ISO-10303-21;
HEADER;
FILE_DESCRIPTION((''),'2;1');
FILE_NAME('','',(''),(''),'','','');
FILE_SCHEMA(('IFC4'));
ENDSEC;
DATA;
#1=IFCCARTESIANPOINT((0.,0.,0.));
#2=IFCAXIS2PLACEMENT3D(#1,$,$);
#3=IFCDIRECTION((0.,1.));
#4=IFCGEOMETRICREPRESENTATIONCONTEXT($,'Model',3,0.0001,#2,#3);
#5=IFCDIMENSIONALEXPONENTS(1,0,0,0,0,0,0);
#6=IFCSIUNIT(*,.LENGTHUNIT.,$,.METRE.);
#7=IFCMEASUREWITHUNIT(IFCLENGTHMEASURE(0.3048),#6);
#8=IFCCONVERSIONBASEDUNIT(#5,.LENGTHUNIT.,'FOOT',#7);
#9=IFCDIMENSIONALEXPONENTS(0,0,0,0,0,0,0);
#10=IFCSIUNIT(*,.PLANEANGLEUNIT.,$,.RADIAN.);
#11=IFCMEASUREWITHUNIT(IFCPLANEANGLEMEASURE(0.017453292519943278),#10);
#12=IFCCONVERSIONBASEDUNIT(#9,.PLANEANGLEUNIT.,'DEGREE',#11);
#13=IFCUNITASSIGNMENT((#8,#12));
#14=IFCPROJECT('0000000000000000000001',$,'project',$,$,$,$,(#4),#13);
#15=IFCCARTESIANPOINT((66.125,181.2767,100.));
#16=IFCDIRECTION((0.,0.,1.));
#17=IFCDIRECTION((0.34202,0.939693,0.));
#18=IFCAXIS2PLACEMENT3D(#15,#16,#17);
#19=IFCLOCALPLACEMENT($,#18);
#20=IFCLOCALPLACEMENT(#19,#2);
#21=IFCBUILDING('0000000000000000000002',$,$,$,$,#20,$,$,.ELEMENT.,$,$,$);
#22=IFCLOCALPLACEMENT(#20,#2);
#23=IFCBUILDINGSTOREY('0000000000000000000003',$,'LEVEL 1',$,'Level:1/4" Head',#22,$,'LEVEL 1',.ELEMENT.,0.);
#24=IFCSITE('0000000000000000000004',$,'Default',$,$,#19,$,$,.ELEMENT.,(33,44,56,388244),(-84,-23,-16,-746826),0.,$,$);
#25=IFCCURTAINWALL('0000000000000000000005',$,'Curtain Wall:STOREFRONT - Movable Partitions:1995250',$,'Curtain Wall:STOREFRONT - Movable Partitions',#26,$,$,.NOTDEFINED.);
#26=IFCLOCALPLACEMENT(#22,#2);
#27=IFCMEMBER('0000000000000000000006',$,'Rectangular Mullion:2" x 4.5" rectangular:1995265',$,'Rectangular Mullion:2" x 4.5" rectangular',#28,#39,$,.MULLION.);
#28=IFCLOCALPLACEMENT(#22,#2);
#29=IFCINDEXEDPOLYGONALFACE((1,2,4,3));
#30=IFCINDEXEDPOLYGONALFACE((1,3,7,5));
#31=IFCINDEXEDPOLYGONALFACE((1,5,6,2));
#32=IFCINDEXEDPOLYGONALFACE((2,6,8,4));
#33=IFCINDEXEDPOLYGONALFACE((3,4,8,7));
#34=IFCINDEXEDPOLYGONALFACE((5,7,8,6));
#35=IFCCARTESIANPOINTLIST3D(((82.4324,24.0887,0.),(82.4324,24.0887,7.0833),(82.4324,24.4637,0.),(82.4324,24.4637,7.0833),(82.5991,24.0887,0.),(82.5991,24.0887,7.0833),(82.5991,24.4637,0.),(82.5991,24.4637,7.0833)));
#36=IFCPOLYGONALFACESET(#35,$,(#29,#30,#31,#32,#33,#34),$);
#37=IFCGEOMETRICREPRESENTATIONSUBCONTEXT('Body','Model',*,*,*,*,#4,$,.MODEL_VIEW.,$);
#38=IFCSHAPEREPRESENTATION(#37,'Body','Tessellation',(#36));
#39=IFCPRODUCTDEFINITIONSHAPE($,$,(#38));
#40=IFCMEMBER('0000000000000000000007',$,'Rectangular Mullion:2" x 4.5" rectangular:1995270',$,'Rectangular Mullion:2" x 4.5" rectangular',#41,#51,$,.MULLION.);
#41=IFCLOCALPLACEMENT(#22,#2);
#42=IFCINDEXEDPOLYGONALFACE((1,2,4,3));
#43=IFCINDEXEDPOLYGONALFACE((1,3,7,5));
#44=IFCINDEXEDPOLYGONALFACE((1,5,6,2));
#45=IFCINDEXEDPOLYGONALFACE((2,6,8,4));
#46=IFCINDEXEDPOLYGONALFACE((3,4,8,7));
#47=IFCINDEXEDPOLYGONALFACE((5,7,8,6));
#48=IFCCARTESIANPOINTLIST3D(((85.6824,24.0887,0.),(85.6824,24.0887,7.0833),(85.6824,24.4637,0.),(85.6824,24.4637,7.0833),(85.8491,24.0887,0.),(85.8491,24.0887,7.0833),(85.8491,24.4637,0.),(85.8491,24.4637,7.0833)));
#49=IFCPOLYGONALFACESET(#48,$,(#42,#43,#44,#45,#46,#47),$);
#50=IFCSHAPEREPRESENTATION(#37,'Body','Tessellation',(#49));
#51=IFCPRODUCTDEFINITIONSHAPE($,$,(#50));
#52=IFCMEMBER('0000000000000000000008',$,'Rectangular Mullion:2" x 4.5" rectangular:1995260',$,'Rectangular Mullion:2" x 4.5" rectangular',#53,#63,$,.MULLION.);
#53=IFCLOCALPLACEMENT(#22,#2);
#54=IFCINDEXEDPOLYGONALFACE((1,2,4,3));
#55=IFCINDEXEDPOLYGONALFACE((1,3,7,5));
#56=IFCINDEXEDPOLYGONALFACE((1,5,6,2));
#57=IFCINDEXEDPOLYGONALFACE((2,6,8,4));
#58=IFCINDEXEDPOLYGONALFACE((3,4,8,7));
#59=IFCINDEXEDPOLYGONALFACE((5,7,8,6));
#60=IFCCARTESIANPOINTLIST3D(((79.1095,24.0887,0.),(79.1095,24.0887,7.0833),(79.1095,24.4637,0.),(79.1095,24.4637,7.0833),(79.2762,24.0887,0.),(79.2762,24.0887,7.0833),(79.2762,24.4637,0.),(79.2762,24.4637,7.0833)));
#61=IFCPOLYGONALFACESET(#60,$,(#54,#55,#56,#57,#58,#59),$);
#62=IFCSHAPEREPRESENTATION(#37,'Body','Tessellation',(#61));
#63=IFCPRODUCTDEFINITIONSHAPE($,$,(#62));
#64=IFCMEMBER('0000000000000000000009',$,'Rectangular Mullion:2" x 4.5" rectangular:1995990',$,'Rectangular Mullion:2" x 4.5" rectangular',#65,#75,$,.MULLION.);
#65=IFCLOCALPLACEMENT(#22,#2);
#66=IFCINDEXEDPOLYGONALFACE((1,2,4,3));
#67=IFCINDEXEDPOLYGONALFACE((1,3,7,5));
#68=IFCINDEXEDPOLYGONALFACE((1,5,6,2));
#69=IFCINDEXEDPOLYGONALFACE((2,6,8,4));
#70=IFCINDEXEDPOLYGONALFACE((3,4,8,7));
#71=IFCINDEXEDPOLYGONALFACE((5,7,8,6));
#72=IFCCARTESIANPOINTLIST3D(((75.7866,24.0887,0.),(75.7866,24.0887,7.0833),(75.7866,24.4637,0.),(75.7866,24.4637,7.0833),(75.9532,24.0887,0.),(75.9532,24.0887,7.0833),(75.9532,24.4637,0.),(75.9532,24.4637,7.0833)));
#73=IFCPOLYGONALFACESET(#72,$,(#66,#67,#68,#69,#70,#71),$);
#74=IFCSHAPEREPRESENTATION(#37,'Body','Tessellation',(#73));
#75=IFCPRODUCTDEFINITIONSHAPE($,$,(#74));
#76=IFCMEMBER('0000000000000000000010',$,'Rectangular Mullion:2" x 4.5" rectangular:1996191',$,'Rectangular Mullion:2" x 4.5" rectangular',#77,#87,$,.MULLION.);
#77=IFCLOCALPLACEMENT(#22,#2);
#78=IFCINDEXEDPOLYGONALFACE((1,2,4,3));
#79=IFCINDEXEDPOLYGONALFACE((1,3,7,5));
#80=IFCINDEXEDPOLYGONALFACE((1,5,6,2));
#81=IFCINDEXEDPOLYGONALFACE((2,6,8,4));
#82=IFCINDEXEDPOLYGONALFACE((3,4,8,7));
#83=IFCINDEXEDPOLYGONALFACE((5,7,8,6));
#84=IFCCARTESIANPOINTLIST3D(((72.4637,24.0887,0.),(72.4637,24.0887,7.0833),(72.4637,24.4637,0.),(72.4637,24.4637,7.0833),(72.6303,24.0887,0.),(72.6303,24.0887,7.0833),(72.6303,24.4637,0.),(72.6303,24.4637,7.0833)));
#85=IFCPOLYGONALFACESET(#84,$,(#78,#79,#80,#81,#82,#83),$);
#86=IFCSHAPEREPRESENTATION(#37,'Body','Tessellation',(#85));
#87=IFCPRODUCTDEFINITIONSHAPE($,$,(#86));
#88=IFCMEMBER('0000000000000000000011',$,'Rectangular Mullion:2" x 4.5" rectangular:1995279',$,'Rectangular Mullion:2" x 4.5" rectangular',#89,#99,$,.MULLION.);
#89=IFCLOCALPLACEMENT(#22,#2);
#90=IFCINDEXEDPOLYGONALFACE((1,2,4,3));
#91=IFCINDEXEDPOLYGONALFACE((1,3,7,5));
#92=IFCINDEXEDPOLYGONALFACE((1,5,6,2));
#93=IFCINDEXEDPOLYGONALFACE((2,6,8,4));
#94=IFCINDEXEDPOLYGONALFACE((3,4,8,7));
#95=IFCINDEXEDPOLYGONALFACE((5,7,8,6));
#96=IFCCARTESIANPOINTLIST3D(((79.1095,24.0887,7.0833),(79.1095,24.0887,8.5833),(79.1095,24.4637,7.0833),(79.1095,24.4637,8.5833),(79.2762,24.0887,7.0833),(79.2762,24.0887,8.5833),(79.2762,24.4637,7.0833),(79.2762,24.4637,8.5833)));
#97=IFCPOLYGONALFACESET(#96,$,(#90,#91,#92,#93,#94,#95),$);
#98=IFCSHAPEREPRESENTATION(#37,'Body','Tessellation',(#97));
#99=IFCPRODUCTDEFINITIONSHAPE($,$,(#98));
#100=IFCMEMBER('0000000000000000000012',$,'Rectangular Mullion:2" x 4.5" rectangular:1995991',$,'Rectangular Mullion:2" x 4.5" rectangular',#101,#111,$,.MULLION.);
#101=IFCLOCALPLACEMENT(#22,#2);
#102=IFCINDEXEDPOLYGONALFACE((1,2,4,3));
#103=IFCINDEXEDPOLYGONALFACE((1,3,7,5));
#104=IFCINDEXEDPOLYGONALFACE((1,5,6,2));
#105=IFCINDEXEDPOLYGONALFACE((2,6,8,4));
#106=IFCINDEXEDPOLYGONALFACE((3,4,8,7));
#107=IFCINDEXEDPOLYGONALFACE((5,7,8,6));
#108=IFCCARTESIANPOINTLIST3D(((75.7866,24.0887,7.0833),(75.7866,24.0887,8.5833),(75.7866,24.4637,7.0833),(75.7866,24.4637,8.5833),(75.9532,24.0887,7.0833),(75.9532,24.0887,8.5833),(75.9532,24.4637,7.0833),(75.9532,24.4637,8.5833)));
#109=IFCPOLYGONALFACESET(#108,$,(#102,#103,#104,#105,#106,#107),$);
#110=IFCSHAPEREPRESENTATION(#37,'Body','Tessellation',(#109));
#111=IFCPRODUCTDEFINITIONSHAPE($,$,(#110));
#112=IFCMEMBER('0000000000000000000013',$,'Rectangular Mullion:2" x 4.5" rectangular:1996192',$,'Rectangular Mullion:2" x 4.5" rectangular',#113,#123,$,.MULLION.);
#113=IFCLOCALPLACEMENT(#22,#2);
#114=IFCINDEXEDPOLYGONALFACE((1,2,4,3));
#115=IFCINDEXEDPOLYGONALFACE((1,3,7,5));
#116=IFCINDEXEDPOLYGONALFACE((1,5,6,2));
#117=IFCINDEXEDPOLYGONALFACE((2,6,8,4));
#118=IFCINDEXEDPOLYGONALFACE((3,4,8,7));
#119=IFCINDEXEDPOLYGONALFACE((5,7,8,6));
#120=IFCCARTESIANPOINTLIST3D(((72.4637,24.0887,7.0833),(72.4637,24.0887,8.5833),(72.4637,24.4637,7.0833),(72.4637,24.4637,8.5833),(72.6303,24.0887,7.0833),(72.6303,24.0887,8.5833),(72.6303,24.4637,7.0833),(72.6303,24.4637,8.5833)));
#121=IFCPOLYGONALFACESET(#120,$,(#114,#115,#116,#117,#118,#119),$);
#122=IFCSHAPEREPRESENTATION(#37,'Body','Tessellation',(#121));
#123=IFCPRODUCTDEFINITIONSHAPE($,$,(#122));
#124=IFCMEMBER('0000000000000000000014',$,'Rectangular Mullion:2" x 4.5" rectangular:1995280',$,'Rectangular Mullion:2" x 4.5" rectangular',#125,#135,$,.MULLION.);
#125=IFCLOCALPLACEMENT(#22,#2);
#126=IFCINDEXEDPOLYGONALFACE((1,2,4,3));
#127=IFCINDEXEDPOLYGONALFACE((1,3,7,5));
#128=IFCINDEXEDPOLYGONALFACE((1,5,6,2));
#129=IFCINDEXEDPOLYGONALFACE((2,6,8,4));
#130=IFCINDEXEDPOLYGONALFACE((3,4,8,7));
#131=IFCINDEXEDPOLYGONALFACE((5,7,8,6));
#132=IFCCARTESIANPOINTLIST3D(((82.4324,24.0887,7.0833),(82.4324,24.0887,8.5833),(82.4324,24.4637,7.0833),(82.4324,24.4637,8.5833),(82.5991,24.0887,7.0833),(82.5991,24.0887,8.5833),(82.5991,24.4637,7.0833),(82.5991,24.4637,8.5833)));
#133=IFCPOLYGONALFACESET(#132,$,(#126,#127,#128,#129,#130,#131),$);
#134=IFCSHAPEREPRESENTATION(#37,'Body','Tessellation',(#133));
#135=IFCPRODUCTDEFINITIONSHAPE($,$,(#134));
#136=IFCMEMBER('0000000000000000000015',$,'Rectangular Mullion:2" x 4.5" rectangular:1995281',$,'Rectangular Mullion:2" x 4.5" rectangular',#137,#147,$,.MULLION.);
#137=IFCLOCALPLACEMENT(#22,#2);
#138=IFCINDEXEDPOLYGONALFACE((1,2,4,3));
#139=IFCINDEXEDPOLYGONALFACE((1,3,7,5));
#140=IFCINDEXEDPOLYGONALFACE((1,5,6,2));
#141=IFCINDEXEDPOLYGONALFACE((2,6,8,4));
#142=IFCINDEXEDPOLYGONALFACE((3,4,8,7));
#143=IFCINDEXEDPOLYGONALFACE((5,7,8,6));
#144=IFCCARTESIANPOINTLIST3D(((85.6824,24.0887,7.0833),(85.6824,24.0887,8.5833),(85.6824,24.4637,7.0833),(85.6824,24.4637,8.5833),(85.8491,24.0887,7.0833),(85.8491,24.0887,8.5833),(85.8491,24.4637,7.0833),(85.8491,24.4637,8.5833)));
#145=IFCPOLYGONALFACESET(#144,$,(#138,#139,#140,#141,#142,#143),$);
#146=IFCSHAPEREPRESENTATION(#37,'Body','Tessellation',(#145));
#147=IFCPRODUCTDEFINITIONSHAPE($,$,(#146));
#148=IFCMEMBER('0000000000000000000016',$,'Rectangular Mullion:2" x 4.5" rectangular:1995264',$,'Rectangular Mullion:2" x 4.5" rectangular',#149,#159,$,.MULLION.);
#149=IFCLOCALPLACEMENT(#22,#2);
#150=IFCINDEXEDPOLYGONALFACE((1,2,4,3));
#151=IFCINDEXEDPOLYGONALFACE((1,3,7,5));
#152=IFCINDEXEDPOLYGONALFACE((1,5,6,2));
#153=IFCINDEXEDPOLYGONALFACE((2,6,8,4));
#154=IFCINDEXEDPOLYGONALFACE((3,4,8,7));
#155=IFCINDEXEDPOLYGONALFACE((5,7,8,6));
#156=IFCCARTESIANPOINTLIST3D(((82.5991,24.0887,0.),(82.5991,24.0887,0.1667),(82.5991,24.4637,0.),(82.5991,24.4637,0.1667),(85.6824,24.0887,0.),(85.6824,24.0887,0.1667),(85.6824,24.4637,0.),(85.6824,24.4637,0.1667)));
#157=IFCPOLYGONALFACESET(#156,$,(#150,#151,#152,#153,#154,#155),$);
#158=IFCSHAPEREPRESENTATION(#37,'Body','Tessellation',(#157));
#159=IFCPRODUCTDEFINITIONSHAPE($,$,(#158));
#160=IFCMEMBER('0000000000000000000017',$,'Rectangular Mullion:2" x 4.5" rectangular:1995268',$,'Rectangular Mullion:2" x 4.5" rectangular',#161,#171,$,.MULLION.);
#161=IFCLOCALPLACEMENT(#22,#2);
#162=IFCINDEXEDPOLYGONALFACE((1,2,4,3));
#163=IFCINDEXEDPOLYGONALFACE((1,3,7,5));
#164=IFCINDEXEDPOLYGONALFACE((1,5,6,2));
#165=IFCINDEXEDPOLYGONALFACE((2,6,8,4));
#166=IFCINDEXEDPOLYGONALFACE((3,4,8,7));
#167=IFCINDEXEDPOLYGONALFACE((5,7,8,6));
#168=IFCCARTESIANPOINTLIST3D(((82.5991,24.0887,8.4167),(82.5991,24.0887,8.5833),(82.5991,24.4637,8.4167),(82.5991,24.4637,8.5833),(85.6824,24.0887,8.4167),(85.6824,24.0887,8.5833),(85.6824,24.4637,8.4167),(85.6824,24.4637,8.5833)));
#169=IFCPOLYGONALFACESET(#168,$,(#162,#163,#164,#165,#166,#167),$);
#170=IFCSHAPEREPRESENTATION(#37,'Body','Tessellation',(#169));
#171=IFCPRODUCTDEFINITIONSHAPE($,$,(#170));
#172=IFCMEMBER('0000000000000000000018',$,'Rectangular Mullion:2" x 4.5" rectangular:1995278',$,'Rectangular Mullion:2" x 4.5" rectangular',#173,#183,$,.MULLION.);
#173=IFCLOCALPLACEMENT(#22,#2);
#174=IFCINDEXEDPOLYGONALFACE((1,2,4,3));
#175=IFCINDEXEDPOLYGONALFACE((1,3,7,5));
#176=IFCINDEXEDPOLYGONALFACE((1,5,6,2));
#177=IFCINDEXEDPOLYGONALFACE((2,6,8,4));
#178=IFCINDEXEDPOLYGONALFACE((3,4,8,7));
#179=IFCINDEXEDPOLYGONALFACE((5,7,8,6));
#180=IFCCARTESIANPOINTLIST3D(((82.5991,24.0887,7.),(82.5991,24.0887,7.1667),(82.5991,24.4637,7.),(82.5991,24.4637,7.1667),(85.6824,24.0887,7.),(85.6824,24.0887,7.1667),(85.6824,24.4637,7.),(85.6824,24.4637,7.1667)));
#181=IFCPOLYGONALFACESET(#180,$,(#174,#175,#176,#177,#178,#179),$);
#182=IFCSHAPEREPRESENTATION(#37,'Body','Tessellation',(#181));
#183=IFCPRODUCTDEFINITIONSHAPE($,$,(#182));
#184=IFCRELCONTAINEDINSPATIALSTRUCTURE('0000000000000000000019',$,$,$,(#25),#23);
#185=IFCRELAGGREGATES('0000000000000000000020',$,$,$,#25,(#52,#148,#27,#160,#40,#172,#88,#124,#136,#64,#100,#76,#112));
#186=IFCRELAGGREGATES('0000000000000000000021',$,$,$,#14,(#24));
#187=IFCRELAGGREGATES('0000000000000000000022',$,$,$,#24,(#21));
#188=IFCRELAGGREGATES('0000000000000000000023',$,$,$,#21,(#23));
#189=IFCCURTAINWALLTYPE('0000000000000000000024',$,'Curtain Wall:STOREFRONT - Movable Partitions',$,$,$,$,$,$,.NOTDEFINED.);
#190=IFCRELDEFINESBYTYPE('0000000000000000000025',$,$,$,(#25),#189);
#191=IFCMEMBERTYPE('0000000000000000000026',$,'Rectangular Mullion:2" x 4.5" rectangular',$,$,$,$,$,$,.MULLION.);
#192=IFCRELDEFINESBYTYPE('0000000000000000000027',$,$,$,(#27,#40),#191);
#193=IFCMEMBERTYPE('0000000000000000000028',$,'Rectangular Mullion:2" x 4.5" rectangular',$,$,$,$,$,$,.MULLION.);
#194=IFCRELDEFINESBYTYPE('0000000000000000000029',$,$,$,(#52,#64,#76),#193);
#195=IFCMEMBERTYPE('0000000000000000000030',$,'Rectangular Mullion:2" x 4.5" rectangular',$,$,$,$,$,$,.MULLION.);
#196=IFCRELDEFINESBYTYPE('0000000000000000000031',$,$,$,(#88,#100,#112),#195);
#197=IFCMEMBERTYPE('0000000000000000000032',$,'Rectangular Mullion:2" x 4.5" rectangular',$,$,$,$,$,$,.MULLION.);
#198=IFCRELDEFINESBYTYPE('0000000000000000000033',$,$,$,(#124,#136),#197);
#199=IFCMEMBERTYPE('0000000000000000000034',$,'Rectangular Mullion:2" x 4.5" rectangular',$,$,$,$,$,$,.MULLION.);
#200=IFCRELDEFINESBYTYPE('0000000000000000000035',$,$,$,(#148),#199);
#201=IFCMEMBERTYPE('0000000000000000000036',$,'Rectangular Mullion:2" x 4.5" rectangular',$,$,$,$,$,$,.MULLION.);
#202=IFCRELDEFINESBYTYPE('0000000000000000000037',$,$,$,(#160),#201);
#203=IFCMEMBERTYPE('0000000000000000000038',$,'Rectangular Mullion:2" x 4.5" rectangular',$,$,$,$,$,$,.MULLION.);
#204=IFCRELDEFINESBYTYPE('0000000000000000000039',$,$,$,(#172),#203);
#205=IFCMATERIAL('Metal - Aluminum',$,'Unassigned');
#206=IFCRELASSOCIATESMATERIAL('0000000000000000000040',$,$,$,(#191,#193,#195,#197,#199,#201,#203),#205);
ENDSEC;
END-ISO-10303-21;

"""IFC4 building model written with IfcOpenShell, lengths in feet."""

from ifc_helpers import new_model, entity, si_unit, converted_unit, direction, frame, frame_2d, origin, origin_2d_with_axis, place, context, subcontext, project, spatial, rectangle, extrude, source, transform, mapped, material, material_profile, profile_set, type_object, type_shapes, element, aggregate, save


model = new_model("IFC4")

# Units and contexts
model_context = context("Model", 3, precision=0.0001, world=origin(), true_north=direction((0.0, 1.0)))
body_context = subcontext(model_context, "Body", "Model", "MODEL_VIEW")
ifc_project = project(units=[converted_unit("LENGTHUNIT", "FOOT", entity("IfcLengthMeasure", 0.3048), si_unit("LENGTHUNIT", "METRE"), dimensions=[1, 0, 0, 0, 0, 0, 0]), converted_unit("PLANEANGLEUNIT", "DEGREE", entity("IfcPlaneAngleMeasure", 0.017453292519943278), si_unit("PLANEANGLEUNIT", "RADIAN"), dimensions=[0, 0, 0, 0, 0, 0, 0])], contexts=[model_context])

# Site, building, storey
site_placement = place(None, frame((66.125, 181.2767, 100.0), z_axis=(0.0, 0.0, 1.0), x_axis=(0.34202, 0.939693, 0.0)))
site = spatial("IfcSite", under=ifc_project, at=site_placement, Name="Default", CompositionType="ELEMENT", RefLatitude=(33, 44, 56, 388244), RefLongitude=(-84, -23, -16, -746826), RefElevation=0.0)
building_placement = place(site_placement, origin())
building = spatial("IfcBuilding", under=site, at=building_placement, CompositionType="ELEMENT")
storey_placement = place(building_placement, origin())
storey = spatial("IfcBuildingStorey", under=building, at=storey_placement, Name="LEVEL 1", ObjectType="Level:1/4\" Head", LongName="LEVEL 1", CompositionType="ELEMENT", Elevation=0.0)

# Curtain wall, members
curtain_wall_type = type_object("IfcCurtainWallType", Name="Curtain Wall:STOREFRONT - Movable Partitions", PredefinedType="NOTDEFINED")
curtain_wall_1_placement = place(storey_placement, origin())
curtain_wall_1 = element("IfcCurtainWall", 1, at=curtain_wall_1_placement, inside=storey, type_object=curtain_wall_type, Name="Curtain Wall:STOREFRONT - Movable Partitions:1995250", ObjectType="Curtain Wall:STOREFRONT - Movable Partitions", PredefinedType="NOTDEFINED")
ifc_material_1 = material(Name="Metal - Aluminum", Category="Unassigned")
ifc_material_profile_1 = material_profile(ifc_material_1, rectangle(XDim=0.1667, YDim=0.375, at=origin_2d_with_axis()), Name="2\" x 4.5\" rectangular")
ifc_profile_set_1 = profile_set([ifc_material_profile_1], Name="2\" x 4.5\" rectangular")
member_type_1 = type_object("IfcMemberType", Name="Rectangular Mullion:2\" x 4.5\" rectangular", PredefinedType="MULLION", material=ifc_profile_set_1)
shared_shape_1 = source(origin(), body_context, "Body", "SweptSolid", [
    extrude(rectangle(XDim=0.1667, YDim=0.375, at=origin_2d_with_axis()), frame((0.0, 0.0, -7.0833), z_axis=(0.0, 0.0, 1.0), x_axis=(-1.0, 0.0, 0.0)), (0.0, 0.0, 1.0), 7.0833),
])
type_shapes(member_type_1, [shared_shape_1])
member_1_placement = place(curtain_wall_1_placement, frame((82.5157, 24.2762, 0.0), z_axis=(0.0, 0.0, -1.0), x_axis=(1.0, 0.0, 0.0)))
member_1 = element("IfcMember", 2, at=member_1_placement, type_object=member_type_1, Name="Rectangular Mullion:2\" x 4.5\" rectangular:1995265", ObjectType="Rectangular Mullion:2\" x 4.5\" rectangular", PredefinedType="MULLION", context=body_context, shape_type="MappedRepresentation", body=[
    mapped(shared_shape_1, transform((0.0, 0.0, 0.0), scale=1.0)),
])
member_2_placement = place(curtain_wall_1_placement, frame((85.7657, 24.2762, 0.0), z_axis=(0.0, 0.0, -1.0), x_axis=(1.0, 0.0, 0.0)))
member_2 = element("IfcMember", 3, at=member_2_placement, type_object=member_type_1, Name="Rectangular Mullion:2\" x 4.5\" rectangular:1995270", ObjectType="Rectangular Mullion:2\" x 4.5\" rectangular", PredefinedType="MULLION", context=body_context, shape_type="MappedRepresentation", body=[
    mapped(shared_shape_1, transform((0.0, 0.0, 0.0), scale=1.0)),
])
member_type_2 = type_object("IfcMemberType", Name="Rectangular Mullion:2\" x 4.5\" rectangular", PredefinedType="MULLION", material=ifc_profile_set_1)
shared_shape_2 = source(origin(), body_context, "Body", "SweptSolid", [
    extrude(rectangle(XDim=0.1667, YDim=0.375, at=origin_2d_with_axis()), frame((0.0, 0.0, -7.0833), z_axis=(0.0, 0.0, 1.0), x_axis=(-1.0, 0.0, 0.0)), (0.0, 0.0, 1.0), 7.0833),
])
type_shapes(member_type_2, [shared_shape_2])
member_3_placement = place(curtain_wall_1_placement, frame((79.1928, 24.2762, 0.0), z_axis=(0.0, 0.0, -1.0), x_axis=(1.0, 0.0, 0.0)))
member_3 = element("IfcMember", 4, at=member_3_placement, type_object=member_type_2, Name="Rectangular Mullion:2\" x 4.5\" rectangular:1995260", ObjectType="Rectangular Mullion:2\" x 4.5\" rectangular", PredefinedType="MULLION", context=body_context, shape_type="MappedRepresentation", body=[
    mapped(shared_shape_2, transform((0.0, 0.0, 0.0), scale=1.0)),
])
member_4_placement = place(curtain_wall_1_placement, frame((75.8699, 24.2762, 0.0), z_axis=(0.0, 0.0, -1.0), x_axis=(1.0, 0.0, 0.0)))
member_4 = element("IfcMember", 5, at=member_4_placement, type_object=member_type_2, Name="Rectangular Mullion:2\" x 4.5\" rectangular:1995990", ObjectType="Rectangular Mullion:2\" x 4.5\" rectangular", PredefinedType="MULLION", context=body_context, shape_type="MappedRepresentation", body=[
    mapped(shared_shape_2, transform((0.0, 0.0, 0.0), scale=1.0)),
])
member_5_placement = place(curtain_wall_1_placement, frame((72.547, 24.2762, 0.0), z_axis=(0.0, 0.0, -1.0), x_axis=(1.0, 0.0, 0.0)))
member_5 = element("IfcMember", 6, at=member_5_placement, type_object=member_type_2, Name="Rectangular Mullion:2\" x 4.5\" rectangular:1996191", ObjectType="Rectangular Mullion:2\" x 4.5\" rectangular", PredefinedType="MULLION", context=body_context, shape_type="MappedRepresentation", body=[
    mapped(shared_shape_2, transform((0.0, 0.0, 0.0), scale=1.0)),
])
member_type_3 = type_object("IfcMemberType", Name="Rectangular Mullion:2\" x 4.5\" rectangular", PredefinedType="MULLION", material=ifc_profile_set_1)
shared_shape_3 = source(origin(), body_context, "Body", "SweptSolid", [
    extrude(rectangle(XDim=0.1667, YDim=0.375, at=origin_2d_with_axis()), frame((0.0, 0.0, -1.5), z_axis=(0.0, 0.0, 1.0), x_axis=(-1.0, 0.0, 0.0)), (0.0, 0.0, 1.0), 1.5),
])
type_shapes(member_type_3, [shared_shape_3])
member_6_placement = place(curtain_wall_1_placement, frame((79.1928, 24.2762, 7.0833), z_axis=(0.0, 0.0, -1.0), x_axis=(1.0, 0.0, 0.0)))
member_6 = element("IfcMember", 7, at=member_6_placement, type_object=member_type_3, Name="Rectangular Mullion:2\" x 4.5\" rectangular:1995279", ObjectType="Rectangular Mullion:2\" x 4.5\" rectangular", PredefinedType="MULLION", context=body_context, shape_type="MappedRepresentation", body=[
    mapped(shared_shape_3, transform((0.0, 0.0, 0.0), scale=1.0)),
])
member_7_placement = place(curtain_wall_1_placement, frame((75.8699, 24.2762, 7.0833), z_axis=(0.0, 0.0, -1.0), x_axis=(1.0, 0.0, 0.0)))
member_7 = element("IfcMember", 8, at=member_7_placement, type_object=member_type_3, Name="Rectangular Mullion:2\" x 4.5\" rectangular:1995991", ObjectType="Rectangular Mullion:2\" x 4.5\" rectangular", PredefinedType="MULLION", context=body_context, shape_type="MappedRepresentation", body=[
    mapped(shared_shape_3, transform((0.0, 0.0, 0.0), scale=1.0)),
])
member_8_placement = place(curtain_wall_1_placement, frame((72.547, 24.2762, 7.0833), z_axis=(0.0, 0.0, -1.0), x_axis=(1.0, 0.0, 0.0)))
member_8 = element("IfcMember", 9, at=member_8_placement, type_object=member_type_3, Name="Rectangular Mullion:2\" x 4.5\" rectangular:1996192", ObjectType="Rectangular Mullion:2\" x 4.5\" rectangular", PredefinedType="MULLION", context=body_context, shape_type="MappedRepresentation", body=[
    mapped(shared_shape_3, transform((0.0, 0.0, 0.0), scale=1.0)),
])
member_type_4 = type_object("IfcMemberType", Name="Rectangular Mullion:2\" x 4.5\" rectangular", PredefinedType="MULLION", material=ifc_profile_set_1)
shared_shape_4 = source(origin(), body_context, "Body", "SweptSolid", [
    extrude(rectangle(XDim=0.1667, YDim=0.375, at=origin_2d_with_axis()), frame((0.0, 0.0, -1.5), z_axis=(0.0, 0.0, 1.0), x_axis=(-1.0, 0.0, 0.0)), (0.0, 0.0, 1.0), 1.5),
])
type_shapes(member_type_4, [shared_shape_4])
member_9_placement = place(curtain_wall_1_placement, frame((82.5157, 24.2762, 7.0833), z_axis=(0.0, 0.0, -1.0), x_axis=(1.0, 0.0, 0.0)))
member_9 = element("IfcMember", 10, at=member_9_placement, type_object=member_type_4, Name="Rectangular Mullion:2\" x 4.5\" rectangular:1995280", ObjectType="Rectangular Mullion:2\" x 4.5\" rectangular", PredefinedType="MULLION", context=body_context, shape_type="MappedRepresentation", body=[
    mapped(shared_shape_4, transform((0.0, 0.0, 0.0), scale=1.0)),
])
member_10_placement = place(curtain_wall_1_placement, frame((85.7657, 24.2762, 7.0833), z_axis=(0.0, 0.0, -1.0), x_axis=(1.0, 0.0, 0.0)))
member_10 = element("IfcMember", 11, at=member_10_placement, type_object=member_type_4, Name="Rectangular Mullion:2\" x 4.5\" rectangular:1995281", ObjectType="Rectangular Mullion:2\" x 4.5\" rectangular", PredefinedType="MULLION", context=body_context, shape_type="MappedRepresentation", body=[
    mapped(shared_shape_4, transform((0.0, 0.0, 0.0), scale=1.0)),
])
member_type_5 = type_object("IfcMemberType", Name="Rectangular Mullion:2\" x 4.5\" rectangular", PredefinedType="MULLION", material=ifc_profile_set_1)
shared_shape_5 = source(origin(), body_context, "Body", "SweptSolid", [
    extrude(rectangle(XDim=0.1667, YDim=0.375, at=origin_2d_with_axis()), frame((-0.0833, 0.0, -3.0833), z_axis=(0.0, 0.0, 1.0), x_axis=(-1.0, 0.0, 0.0)), (0.0, 0.0, 1.0), 3.0833),
])
type_shapes(member_type_5, [shared_shape_5])
member_11_placement = place(curtain_wall_1_placement, frame((82.5991, 24.2762, 0.0), z_axis=(-1.0, 0.0, 0.0), x_axis=(0.0, 0.0, -1.0)))
member_11 = element("IfcMember", 12, at=member_11_placement, type_object=member_type_5, Name="Rectangular Mullion:2\" x 4.5\" rectangular:1995264", ObjectType="Rectangular Mullion:2\" x 4.5\" rectangular", PredefinedType="MULLION", context=body_context, shape_type="MappedRepresentation", body=[
    mapped(shared_shape_5, transform((0.0, 0.0, 0.0), scale=1.0)),
])
member_type_6 = type_object("IfcMemberType", Name="Rectangular Mullion:2\" x 4.5\" rectangular", PredefinedType="MULLION", material=ifc_profile_set_1)
shared_shape_6 = source(origin(), body_context, "Body", "SweptSolid", [
    extrude(rectangle(XDim=0.1667, YDim=0.375, at=origin_2d_with_axis()), frame((-0.0833, 0.0, -3.0833), z_axis=(0.0, 0.0, 1.0), x_axis=(-1.0, 0.0, 0.0)), (0.0, 0.0, 1.0), 3.0833),
])
type_shapes(member_type_6, [shared_shape_6])
member_12_placement = place(curtain_wall_1_placement, frame((85.6824, 24.2762, 8.5833), z_axis=(1.0, 0.0, 0.0), x_axis=(0.0, 0.0, 1.0)))
member_12 = element("IfcMember", 13, at=member_12_placement, type_object=member_type_6, Name="Rectangular Mullion:2\" x 4.5\" rectangular:1995268", ObjectType="Rectangular Mullion:2\" x 4.5\" rectangular", PredefinedType="MULLION", context=body_context, shape_type="MappedRepresentation", body=[
    mapped(shared_shape_6, transform((0.0, 0.0, 0.0), scale=1.0)),
])
member_type_7 = type_object("IfcMemberType", Name="Rectangular Mullion:2\" x 4.5\" rectangular", PredefinedType="MULLION", material=ifc_profile_set_1)
shared_shape_7 = source(origin(), body_context, "Body", "SweptSolid", [
    extrude(rectangle(XDim=0.1667, YDim=0.375, at=frame_2d((0.0, 0.0), x_axis=(1.0, 0.0))), frame((0.0, 0.0, -3.0833), z_axis=(0.0, 0.0, 1.0), x_axis=(-1.0, 0.0, 0.0)), (0.0, 0.0, 1.0), 3.0833),
])
type_shapes(member_type_7, [shared_shape_7])
member_13_placement = place(curtain_wall_1_placement, frame((85.6824, 24.2762, 7.0833), z_axis=(1.0, 0.0, 0.0), x_axis=(0.0, 0.0, 1.0)))
member_13 = element("IfcMember", 14, at=member_13_placement, type_object=member_type_7, Name="Rectangular Mullion:2\" x 4.5\" rectangular:1995278", ObjectType="Rectangular Mullion:2\" x 4.5\" rectangular", PredefinedType="MULLION", context=body_context, shape_type="MappedRepresentation", body=[
    mapped(shared_shape_7, transform((0.0, 0.0, 0.0), scale=1.0)),
])

aggregate(curtain_wall_1, [member_3, member_11, member_1, member_12, member_2, member_13, member_6, member_9, member_10, member_4, member_7, member_5, member_8])

save(model, "model.ifc")
